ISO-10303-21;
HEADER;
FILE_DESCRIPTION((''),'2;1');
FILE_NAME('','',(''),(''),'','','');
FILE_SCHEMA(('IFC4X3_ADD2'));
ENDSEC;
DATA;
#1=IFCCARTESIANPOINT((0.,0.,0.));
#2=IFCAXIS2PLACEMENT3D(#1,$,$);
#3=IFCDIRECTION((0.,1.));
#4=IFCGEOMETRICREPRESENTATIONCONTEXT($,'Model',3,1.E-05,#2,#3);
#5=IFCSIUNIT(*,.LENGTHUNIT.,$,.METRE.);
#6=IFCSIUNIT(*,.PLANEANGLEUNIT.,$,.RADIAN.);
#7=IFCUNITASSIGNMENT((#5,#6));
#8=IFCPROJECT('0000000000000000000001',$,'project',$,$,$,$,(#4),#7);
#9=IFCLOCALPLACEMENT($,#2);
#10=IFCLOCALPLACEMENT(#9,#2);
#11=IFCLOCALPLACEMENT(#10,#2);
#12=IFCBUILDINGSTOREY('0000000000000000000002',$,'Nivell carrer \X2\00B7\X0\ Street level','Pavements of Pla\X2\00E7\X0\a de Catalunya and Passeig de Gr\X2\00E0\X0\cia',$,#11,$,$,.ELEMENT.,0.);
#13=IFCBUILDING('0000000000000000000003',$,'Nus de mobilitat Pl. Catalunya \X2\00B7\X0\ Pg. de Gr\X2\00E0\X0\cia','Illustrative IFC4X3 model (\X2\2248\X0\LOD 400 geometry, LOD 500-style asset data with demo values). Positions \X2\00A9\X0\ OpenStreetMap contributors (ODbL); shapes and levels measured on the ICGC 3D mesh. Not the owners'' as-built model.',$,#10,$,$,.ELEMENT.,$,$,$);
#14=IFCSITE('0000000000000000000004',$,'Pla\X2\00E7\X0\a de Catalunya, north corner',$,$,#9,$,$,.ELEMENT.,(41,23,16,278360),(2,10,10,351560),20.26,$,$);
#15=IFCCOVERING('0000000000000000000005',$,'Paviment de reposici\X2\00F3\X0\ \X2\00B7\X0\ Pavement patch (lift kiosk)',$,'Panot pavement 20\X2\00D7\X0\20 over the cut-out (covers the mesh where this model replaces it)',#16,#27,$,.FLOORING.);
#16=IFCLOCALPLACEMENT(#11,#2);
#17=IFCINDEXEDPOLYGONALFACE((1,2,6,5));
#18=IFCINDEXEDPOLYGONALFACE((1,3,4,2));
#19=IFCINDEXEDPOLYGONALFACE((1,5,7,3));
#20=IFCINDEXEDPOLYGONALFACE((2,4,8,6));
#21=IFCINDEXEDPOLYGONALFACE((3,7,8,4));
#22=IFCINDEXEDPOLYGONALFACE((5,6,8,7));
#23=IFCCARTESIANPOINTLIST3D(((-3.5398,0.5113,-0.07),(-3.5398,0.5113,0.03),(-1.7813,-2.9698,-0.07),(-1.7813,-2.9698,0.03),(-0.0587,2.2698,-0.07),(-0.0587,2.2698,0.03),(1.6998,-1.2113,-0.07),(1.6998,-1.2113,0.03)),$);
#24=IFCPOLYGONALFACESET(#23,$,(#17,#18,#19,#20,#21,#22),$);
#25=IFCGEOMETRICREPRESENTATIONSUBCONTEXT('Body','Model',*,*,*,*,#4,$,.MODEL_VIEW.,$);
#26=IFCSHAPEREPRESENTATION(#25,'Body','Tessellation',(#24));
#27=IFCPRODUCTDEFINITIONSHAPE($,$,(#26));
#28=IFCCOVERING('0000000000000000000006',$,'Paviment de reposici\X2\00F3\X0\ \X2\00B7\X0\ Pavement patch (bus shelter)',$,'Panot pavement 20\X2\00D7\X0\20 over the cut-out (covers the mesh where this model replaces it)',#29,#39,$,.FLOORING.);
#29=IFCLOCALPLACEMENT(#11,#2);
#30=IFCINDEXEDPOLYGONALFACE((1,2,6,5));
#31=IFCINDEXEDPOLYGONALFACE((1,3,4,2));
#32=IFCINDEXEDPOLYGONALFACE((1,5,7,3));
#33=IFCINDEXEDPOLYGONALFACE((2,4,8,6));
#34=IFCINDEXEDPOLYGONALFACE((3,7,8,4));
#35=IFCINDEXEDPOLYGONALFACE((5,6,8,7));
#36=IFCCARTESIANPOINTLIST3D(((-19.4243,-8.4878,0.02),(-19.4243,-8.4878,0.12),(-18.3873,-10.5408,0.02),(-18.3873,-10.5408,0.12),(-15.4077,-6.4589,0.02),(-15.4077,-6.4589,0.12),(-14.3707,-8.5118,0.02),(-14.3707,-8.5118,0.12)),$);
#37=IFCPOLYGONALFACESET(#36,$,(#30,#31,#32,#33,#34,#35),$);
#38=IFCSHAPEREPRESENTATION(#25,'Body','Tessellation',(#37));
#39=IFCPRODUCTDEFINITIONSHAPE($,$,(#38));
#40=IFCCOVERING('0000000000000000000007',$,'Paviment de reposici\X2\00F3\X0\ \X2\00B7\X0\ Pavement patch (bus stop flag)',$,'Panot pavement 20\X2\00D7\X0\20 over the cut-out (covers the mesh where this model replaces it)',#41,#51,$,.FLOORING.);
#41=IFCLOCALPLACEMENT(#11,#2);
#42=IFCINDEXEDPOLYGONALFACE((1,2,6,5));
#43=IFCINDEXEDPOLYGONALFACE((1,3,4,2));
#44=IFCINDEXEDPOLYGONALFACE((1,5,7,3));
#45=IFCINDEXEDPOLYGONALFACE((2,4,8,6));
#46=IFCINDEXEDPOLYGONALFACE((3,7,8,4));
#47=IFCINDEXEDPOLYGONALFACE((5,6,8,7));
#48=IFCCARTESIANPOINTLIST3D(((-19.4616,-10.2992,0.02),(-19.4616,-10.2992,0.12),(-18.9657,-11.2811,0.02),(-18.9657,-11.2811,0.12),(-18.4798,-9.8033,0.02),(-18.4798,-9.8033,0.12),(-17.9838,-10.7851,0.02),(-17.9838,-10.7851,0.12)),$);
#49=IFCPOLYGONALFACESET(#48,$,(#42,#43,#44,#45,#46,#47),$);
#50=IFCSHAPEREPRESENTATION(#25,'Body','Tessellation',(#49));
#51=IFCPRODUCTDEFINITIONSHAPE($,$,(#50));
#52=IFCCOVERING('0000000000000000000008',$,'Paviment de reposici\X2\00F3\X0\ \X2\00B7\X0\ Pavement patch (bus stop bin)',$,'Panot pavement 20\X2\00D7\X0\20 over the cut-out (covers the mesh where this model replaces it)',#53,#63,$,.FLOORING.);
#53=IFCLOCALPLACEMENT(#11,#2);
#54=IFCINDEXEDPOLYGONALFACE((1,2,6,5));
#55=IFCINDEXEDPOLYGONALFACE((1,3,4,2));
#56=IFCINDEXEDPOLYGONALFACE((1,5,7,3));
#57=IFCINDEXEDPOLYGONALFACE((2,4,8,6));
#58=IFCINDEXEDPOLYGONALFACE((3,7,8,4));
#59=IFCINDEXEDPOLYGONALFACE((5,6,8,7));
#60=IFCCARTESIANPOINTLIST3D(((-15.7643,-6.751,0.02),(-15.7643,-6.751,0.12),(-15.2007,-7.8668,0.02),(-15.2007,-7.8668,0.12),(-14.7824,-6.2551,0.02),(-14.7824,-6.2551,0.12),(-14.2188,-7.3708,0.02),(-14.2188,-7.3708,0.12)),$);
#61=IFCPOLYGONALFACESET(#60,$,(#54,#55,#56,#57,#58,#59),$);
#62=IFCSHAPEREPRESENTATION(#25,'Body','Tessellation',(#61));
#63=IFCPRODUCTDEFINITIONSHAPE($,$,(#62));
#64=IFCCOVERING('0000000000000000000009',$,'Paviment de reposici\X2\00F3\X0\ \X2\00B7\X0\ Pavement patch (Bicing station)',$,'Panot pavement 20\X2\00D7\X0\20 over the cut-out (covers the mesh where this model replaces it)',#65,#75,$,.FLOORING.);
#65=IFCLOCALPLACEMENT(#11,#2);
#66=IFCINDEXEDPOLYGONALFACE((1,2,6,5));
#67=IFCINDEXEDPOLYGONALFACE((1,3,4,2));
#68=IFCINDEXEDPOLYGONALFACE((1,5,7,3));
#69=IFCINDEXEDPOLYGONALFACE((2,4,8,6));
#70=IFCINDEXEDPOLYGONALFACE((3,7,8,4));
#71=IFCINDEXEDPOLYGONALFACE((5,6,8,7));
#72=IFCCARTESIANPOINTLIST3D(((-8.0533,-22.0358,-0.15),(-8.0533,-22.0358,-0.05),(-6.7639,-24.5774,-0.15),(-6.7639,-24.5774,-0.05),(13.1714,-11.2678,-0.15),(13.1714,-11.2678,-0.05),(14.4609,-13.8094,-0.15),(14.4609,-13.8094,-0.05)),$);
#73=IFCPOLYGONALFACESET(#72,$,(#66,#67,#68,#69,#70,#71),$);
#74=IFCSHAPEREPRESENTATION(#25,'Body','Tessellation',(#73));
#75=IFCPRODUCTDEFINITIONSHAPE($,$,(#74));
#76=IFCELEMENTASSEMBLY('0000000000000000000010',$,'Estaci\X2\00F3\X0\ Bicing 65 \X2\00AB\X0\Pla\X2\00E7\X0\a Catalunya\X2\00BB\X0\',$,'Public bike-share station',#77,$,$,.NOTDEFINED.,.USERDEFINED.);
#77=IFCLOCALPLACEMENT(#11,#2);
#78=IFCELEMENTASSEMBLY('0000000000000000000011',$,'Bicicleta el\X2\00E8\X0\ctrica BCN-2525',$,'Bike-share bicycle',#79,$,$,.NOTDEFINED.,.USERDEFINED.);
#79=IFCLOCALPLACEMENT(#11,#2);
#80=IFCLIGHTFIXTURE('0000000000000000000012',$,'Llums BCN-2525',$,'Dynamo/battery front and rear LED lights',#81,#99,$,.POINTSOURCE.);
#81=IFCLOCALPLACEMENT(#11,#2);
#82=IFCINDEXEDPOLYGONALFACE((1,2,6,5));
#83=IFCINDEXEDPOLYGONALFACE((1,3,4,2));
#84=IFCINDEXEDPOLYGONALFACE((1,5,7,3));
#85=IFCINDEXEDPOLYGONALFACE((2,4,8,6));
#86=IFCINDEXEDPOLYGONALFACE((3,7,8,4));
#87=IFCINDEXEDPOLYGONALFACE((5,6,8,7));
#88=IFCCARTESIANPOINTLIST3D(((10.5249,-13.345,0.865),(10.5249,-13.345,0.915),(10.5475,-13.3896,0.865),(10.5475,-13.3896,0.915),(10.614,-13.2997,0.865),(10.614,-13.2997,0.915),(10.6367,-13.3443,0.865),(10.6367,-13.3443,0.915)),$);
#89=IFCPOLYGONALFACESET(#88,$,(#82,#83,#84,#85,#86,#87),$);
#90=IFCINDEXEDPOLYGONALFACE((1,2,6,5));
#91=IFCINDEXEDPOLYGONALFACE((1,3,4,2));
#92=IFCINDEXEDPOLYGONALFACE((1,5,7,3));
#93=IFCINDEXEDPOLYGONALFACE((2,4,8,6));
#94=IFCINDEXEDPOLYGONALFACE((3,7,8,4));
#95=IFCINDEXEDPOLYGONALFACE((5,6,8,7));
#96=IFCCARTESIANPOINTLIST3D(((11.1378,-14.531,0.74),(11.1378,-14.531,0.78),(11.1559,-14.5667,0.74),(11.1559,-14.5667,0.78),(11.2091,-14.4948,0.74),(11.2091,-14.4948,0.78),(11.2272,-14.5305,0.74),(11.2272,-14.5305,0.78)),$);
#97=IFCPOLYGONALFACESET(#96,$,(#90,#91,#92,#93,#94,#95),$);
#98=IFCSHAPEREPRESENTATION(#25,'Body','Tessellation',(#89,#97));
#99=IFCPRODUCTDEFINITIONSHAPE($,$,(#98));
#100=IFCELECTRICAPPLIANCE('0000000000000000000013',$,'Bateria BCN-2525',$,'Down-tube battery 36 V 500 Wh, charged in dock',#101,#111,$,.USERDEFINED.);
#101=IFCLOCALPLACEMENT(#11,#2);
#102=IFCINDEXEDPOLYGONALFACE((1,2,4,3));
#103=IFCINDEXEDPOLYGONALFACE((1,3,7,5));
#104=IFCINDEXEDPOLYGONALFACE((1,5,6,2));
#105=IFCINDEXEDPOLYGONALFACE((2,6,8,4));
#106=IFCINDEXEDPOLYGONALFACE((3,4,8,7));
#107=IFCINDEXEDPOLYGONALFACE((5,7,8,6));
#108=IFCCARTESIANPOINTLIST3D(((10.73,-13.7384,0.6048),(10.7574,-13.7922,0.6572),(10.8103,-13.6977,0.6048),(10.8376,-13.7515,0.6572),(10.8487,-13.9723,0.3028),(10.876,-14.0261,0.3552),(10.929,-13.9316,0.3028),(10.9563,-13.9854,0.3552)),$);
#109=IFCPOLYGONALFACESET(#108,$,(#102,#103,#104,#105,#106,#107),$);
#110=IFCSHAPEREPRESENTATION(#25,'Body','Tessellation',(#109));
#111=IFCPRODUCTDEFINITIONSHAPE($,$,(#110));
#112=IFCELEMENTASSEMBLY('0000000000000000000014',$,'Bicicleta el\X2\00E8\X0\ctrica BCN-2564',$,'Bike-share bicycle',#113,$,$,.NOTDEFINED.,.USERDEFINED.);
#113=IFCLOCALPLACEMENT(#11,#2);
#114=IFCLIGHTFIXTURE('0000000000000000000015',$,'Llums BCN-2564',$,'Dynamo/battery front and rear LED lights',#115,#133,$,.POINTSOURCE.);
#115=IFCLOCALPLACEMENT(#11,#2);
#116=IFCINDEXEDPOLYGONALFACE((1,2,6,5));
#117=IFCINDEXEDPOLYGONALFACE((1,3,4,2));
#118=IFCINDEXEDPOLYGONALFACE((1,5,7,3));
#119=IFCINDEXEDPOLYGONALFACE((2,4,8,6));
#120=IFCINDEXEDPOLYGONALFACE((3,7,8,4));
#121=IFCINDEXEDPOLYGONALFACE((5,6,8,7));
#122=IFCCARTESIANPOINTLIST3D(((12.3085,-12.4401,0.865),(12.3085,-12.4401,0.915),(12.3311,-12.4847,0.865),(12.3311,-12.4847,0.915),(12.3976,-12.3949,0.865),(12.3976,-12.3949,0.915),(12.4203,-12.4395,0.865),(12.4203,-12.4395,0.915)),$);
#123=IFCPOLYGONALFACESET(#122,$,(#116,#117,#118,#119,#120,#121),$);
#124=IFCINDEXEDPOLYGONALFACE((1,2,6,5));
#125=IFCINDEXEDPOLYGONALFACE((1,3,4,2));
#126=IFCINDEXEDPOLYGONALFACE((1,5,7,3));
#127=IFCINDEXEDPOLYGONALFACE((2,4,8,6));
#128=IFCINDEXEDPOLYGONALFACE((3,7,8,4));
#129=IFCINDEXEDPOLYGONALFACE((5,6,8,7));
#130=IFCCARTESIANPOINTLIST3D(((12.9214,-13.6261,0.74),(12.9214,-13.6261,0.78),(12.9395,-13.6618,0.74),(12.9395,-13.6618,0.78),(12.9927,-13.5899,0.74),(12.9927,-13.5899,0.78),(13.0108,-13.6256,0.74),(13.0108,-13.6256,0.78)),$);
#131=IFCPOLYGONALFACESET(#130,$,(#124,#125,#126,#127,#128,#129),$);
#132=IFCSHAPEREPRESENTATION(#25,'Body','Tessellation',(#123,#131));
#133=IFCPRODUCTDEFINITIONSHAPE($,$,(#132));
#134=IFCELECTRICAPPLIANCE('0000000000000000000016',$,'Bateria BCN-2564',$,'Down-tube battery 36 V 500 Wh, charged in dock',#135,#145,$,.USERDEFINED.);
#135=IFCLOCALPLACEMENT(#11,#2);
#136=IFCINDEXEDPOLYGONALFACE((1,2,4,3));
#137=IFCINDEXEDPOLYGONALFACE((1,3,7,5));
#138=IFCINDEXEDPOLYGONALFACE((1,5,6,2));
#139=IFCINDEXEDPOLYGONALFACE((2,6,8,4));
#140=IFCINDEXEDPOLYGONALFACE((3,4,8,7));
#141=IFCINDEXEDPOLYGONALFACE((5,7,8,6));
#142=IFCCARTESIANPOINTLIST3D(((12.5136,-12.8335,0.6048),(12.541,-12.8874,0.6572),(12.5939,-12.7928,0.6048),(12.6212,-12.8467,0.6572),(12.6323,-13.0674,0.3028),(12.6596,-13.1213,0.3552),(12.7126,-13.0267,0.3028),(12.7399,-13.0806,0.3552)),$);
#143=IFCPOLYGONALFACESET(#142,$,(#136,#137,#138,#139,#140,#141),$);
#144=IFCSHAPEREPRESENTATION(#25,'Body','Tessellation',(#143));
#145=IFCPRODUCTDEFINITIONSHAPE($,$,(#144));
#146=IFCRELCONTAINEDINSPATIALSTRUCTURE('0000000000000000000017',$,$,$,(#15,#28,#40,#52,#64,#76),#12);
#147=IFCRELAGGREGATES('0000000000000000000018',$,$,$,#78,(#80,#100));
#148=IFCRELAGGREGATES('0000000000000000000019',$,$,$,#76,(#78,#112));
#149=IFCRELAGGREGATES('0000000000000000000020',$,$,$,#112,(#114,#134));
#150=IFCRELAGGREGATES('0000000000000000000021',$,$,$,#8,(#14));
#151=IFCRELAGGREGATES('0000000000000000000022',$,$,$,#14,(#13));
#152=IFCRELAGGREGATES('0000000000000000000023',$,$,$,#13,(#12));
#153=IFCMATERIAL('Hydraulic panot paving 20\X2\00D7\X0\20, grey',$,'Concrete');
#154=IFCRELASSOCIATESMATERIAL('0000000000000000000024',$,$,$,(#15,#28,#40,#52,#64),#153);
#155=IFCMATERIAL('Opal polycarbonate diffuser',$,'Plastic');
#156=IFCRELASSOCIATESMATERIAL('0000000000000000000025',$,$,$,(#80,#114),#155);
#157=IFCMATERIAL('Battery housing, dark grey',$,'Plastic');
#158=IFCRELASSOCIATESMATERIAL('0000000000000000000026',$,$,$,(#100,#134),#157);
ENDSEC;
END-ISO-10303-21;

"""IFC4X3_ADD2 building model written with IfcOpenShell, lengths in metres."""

from ifc_helpers import new_model, si_unit, direction, frame, frame_2d, origin, origin_2d_with_axis, place, context, subcontext, project, spatial, rectangle, extrude, material, element, aggregate, save


model = new_model("IFC4X3_ADD2")

# Units and contexts
model_context = context("Model", 3, precision=1e-05, world=origin(), true_north=direction((0.0, 1.0)))
body_context = subcontext(model_context, "Body", "Model", "MODEL_VIEW")
ifc_project = project(units=[si_unit("LENGTHUNIT", "METRE"), si_unit("PLANEANGLEUNIT", "RADIAN")], contexts=[model_context])

# Site, building, storey
site_placement = place(None, origin())
site = spatial("IfcSite", under=ifc_project, at=site_placement, Name="Plaça de Catalunya, north corner", CompositionType="ELEMENT", RefLatitude=(41, 23, 16, 278360), RefLongitude=(2, 10, 10, 351560), RefElevation=20.26)
building_placement = place(site_placement, origin())
building = spatial("IfcBuilding", under=site, at=building_placement, Name="Nus de mobilitat Pl. Catalunya · Pg. de Gràcia", Description="Illustrative IFC4X3 model (≈LOD 400 geometry, LOD 500-style asset data with demo values). Positions © OpenStreetMap contributors (ODbL); shapes and levels measured on the ICGC 3D mesh. Not the owners' as-built model.", CompositionType="ELEMENT")
storey_placement = place(building_placement, origin())
storey = spatial("IfcBuildingStorey", under=building, at=storey_placement, Name="Nivell carrer · Street level", Description="Pavements of Plaça de Catalunya and Passeig de Gràcia", CompositionType="ELEMENT", Elevation=0.0)

# Coverings
ifc_material_1 = material(Name="Hydraulic panot paving 20×20, grey", Category="Concrete")
covering_1_placement = place(building_placement, origin())
element("IfcCovering", 1, at=covering_1_placement, inside=storey, material=ifc_material_1, Name="Paviment de reposició · Pavement patch (lift kiosk)", ObjectType="Panot pavement 20×20 over the cut-out (covers the mesh where this model replaces it)", PredefinedType="FLOORING", context=body_context, shape_type="SweptSolid", body=[
    extrude(rectangle(XDim=3.9, YDim=3.9, at=frame_2d((0.0, 0.0), x_axis=(0.892586, 0.450878))), frame((-0.92, -0.35, -0.07)), (0.0, 0.0, 1.0), 0.1),
])
covering_2_placement = place(building_placement, origin())
element("IfcCovering", 2, at=covering_2_placement, inside=storey, material=ifc_material_1, Name="Paviment de reposició · Pavement patch (bus shelter)", ObjectType="Panot pavement 20×20 over the cut-out (covers the mesh where this model replaces it)", PredefinedType="FLOORING", context=body_context, shape_type="SweptSolid", body=[
    extrude(rectangle(XDim=4.5, YDim=2.3, at=frame_2d((0.0, 0.0), x_axis=(0.892586, 0.450878))), frame((-16.8975, -8.4998, 0.02)), (0.0, 0.0, 1.0), 0.1),
])
covering_3_placement = place(building_placement, origin())
element("IfcCovering", 3, at=covering_3_placement, inside=storey, material=ifc_material_1, Name="Paviment de reposició · Pavement patch (bus stop flag)", ObjectType="Panot pavement 20×20 over the cut-out (covers the mesh where this model replaces it)", PredefinedType="FLOORING", context=body_context, shape_type="SweptSolid", body=[
    extrude(rectangle(XDim=1.1, YDim=1.1, at=frame_2d((0.0, 0.0), x_axis=(0.892586, 0.450878))), frame((-18.7227, -10.5422, 0.02)), (0.0, 0.0, 1.0), 0.1),
])
covering_4_placement = place(building_placement, origin())
element("IfcCovering", 4, at=covering_4_placement, inside=storey, material=ifc_material_1, Name="Paviment de reposició · Pavement patch (bus stop bin)", ObjectType="Panot pavement 20×20 over the cut-out (covers the mesh where this model replaces it)", PredefinedType="FLOORING", context=body_context, shape_type="SweptSolid", body=[
    extrude(rectangle(XDim=1.1, YDim=1.25, at=frame_2d((0.0, 0.0), x_axis=(0.892586, 0.450878))), frame((-14.9916, -7.0609, 0.02)), (0.0, 0.0, 1.0), 0.1),
])
covering_5_placement = place(building_placement, origin())
element("IfcCovering", 5, at=covering_5_placement, inside=storey, material=ifc_material_1, Name="Paviment de reposició · Pavement patch (Bicing station)", ObjectType="Panot pavement 20×20 over the cut-out (covers the mesh where this model replaces it)", PredefinedType="FLOORING", context=body_context, shape_type="SweptSolid", body=[
    extrude(rectangle(XDim=23.8, YDim=2.85, at=frame_2d((0.0, 0.0), x_axis=(0.891798, 0.452435))), frame((3.2038, -17.9226, -0.15)), (0.0, 0.0, 1.0), 0.1),
])

# Element assemblies, light fixtures, electric appliances
assembly_1_placement = place(building_placement, origin())
assembly_1 = element("IfcElementAssembly", 6, at=assembly_1_placement, inside=storey, Name="Estació Bicing 65 «Plaça Catalunya»", ObjectType="Public bike-share station", AssemblyPlace="NOTDEFINED", PredefinedType="USERDEFINED")
assembly_2_placement = place(building_placement, origin())
assembly_2 = element("IfcElementAssembly", 7, at=assembly_2_placement, Name="Bicicleta elèctrica BCN-2525", ObjectType="Bike-share bicycle", AssemblyPlace="NOTDEFINED", PredefinedType="USERDEFINED")
ifc_material_2 = material(Name="Opal polycarbonate diffuser", Category="Plastic")
light_fixture_1_placement = place(building_placement, origin())
light_fixture_1 = element("IfcLightFixture", 8, at=light_fixture_1_placement, material=ifc_material_2, Name="Llums BCN-2525", ObjectType="Dynamo/battery front and rear LED lights", PredefinedType="POINTSOURCE", context=body_context, shape_type="SweptSolid", body=[
    extrude(rectangle(XDim=0.05, YDim=0.1, at=origin_2d_with_axis()), frame((10.5808, -13.3447, 0.915), z_axis=(0.0, 0.0, -1.0), x_axis=(-0.452435, 0.891798, 0.0)), (0.0, 0.0, 1.0), 0.05),
    extrude(rectangle(XDim=0.04, YDim=0.08, at=origin_2d_with_axis()), frame((11.1825, -14.5307, 0.78), z_axis=(0.0, 0.0, -1.0), x_axis=(-0.452435, 0.891798, 0.0)), (0.0, 0.0, 1.0), 0.04),
])
ifc_material_3 = material(Name="Battery housing, dark grey", Category="Plastic")
electric_appliance_1_placement = place(building_placement, origin())
electric_appliance_1 = element("IfcElectricAppliance", 9, at=electric_appliance_1_placement, material=ifc_material_3, Name="Bateria BCN-2525", ObjectType="Down-tube battery 36 V 500 Wh, charged in dock", PredefinedType="USERDEFINED", context=body_context, shape_type="SweptSolid", body=[
    extrude(rectangle(XDim=0.4, YDim=0.09, at=origin_2d_with_axis()), frame((10.8568, -13.8888, 0.5062), z_axis=(-0.341603, 0.673337, -0.655687), x_axis=(-0.296655, 0.58474, 0.755033)), (0.0, 0.0, 1.0), 0.08),
])
aggregate(assembly_2, [light_fixture_1, electric_appliance_1])
assembly_3_placement = place(building_placement, origin())
assembly_3 = element("IfcElementAssembly", 10, at=assembly_3_placement, Name="Bicicleta elèctrica BCN-2564", ObjectType="Bike-share bicycle", AssemblyPlace="NOTDEFINED", PredefinedType="USERDEFINED")
aggregate(assembly_1, [assembly_2, assembly_3])
light_fixture_2_placement = place(building_placement, origin())
light_fixture_2 = element("IfcLightFixture", 11, at=light_fixture_2_placement, material=ifc_material_2, Name="Llums BCN-2564", ObjectType="Dynamo/battery front and rear LED lights", PredefinedType="POINTSOURCE", context=body_context, shape_type="SweptSolid", body=[
    extrude(rectangle(XDim=0.05, YDim=0.1, at=origin_2d_with_axis()), frame((12.3644, -12.4398, 0.915), z_axis=(0.0, 0.0, -1.0), x_axis=(-0.452435, 0.891798, 0.0)), (0.0, 0.0, 1.0), 0.05),
    extrude(rectangle(XDim=0.04, YDim=0.08, at=origin_2d_with_axis()), frame((12.9661, -13.6259, 0.78), z_axis=(0.0, 0.0, -1.0), x_axis=(-0.452435, 0.891798, 0.0)), (0.0, 0.0, 1.0), 0.04),
])
electric_appliance_2_placement = place(building_placement, origin())
electric_appliance_2 = element("IfcElectricAppliance", 12, at=electric_appliance_2_placement, material=ifc_material_3, Name="Bateria BCN-2564", ObjectType="Down-tube battery 36 V 500 Wh, charged in dock", PredefinedType="USERDEFINED", context=body_context, shape_type="SweptSolid", body=[
    extrude(rectangle(XDim=0.4, YDim=0.09, at=origin_2d_with_axis()), frame((12.6404, -12.984, 0.5062), z_axis=(-0.341603, 0.673337, -0.655687), x_axis=(-0.296655, 0.58474, 0.755033)), (0.0, 0.0, 1.0), 0.08),
])

aggregate(assembly_3, [light_fixture_2, electric_appliance_2])

save(model, "model.ifc")
